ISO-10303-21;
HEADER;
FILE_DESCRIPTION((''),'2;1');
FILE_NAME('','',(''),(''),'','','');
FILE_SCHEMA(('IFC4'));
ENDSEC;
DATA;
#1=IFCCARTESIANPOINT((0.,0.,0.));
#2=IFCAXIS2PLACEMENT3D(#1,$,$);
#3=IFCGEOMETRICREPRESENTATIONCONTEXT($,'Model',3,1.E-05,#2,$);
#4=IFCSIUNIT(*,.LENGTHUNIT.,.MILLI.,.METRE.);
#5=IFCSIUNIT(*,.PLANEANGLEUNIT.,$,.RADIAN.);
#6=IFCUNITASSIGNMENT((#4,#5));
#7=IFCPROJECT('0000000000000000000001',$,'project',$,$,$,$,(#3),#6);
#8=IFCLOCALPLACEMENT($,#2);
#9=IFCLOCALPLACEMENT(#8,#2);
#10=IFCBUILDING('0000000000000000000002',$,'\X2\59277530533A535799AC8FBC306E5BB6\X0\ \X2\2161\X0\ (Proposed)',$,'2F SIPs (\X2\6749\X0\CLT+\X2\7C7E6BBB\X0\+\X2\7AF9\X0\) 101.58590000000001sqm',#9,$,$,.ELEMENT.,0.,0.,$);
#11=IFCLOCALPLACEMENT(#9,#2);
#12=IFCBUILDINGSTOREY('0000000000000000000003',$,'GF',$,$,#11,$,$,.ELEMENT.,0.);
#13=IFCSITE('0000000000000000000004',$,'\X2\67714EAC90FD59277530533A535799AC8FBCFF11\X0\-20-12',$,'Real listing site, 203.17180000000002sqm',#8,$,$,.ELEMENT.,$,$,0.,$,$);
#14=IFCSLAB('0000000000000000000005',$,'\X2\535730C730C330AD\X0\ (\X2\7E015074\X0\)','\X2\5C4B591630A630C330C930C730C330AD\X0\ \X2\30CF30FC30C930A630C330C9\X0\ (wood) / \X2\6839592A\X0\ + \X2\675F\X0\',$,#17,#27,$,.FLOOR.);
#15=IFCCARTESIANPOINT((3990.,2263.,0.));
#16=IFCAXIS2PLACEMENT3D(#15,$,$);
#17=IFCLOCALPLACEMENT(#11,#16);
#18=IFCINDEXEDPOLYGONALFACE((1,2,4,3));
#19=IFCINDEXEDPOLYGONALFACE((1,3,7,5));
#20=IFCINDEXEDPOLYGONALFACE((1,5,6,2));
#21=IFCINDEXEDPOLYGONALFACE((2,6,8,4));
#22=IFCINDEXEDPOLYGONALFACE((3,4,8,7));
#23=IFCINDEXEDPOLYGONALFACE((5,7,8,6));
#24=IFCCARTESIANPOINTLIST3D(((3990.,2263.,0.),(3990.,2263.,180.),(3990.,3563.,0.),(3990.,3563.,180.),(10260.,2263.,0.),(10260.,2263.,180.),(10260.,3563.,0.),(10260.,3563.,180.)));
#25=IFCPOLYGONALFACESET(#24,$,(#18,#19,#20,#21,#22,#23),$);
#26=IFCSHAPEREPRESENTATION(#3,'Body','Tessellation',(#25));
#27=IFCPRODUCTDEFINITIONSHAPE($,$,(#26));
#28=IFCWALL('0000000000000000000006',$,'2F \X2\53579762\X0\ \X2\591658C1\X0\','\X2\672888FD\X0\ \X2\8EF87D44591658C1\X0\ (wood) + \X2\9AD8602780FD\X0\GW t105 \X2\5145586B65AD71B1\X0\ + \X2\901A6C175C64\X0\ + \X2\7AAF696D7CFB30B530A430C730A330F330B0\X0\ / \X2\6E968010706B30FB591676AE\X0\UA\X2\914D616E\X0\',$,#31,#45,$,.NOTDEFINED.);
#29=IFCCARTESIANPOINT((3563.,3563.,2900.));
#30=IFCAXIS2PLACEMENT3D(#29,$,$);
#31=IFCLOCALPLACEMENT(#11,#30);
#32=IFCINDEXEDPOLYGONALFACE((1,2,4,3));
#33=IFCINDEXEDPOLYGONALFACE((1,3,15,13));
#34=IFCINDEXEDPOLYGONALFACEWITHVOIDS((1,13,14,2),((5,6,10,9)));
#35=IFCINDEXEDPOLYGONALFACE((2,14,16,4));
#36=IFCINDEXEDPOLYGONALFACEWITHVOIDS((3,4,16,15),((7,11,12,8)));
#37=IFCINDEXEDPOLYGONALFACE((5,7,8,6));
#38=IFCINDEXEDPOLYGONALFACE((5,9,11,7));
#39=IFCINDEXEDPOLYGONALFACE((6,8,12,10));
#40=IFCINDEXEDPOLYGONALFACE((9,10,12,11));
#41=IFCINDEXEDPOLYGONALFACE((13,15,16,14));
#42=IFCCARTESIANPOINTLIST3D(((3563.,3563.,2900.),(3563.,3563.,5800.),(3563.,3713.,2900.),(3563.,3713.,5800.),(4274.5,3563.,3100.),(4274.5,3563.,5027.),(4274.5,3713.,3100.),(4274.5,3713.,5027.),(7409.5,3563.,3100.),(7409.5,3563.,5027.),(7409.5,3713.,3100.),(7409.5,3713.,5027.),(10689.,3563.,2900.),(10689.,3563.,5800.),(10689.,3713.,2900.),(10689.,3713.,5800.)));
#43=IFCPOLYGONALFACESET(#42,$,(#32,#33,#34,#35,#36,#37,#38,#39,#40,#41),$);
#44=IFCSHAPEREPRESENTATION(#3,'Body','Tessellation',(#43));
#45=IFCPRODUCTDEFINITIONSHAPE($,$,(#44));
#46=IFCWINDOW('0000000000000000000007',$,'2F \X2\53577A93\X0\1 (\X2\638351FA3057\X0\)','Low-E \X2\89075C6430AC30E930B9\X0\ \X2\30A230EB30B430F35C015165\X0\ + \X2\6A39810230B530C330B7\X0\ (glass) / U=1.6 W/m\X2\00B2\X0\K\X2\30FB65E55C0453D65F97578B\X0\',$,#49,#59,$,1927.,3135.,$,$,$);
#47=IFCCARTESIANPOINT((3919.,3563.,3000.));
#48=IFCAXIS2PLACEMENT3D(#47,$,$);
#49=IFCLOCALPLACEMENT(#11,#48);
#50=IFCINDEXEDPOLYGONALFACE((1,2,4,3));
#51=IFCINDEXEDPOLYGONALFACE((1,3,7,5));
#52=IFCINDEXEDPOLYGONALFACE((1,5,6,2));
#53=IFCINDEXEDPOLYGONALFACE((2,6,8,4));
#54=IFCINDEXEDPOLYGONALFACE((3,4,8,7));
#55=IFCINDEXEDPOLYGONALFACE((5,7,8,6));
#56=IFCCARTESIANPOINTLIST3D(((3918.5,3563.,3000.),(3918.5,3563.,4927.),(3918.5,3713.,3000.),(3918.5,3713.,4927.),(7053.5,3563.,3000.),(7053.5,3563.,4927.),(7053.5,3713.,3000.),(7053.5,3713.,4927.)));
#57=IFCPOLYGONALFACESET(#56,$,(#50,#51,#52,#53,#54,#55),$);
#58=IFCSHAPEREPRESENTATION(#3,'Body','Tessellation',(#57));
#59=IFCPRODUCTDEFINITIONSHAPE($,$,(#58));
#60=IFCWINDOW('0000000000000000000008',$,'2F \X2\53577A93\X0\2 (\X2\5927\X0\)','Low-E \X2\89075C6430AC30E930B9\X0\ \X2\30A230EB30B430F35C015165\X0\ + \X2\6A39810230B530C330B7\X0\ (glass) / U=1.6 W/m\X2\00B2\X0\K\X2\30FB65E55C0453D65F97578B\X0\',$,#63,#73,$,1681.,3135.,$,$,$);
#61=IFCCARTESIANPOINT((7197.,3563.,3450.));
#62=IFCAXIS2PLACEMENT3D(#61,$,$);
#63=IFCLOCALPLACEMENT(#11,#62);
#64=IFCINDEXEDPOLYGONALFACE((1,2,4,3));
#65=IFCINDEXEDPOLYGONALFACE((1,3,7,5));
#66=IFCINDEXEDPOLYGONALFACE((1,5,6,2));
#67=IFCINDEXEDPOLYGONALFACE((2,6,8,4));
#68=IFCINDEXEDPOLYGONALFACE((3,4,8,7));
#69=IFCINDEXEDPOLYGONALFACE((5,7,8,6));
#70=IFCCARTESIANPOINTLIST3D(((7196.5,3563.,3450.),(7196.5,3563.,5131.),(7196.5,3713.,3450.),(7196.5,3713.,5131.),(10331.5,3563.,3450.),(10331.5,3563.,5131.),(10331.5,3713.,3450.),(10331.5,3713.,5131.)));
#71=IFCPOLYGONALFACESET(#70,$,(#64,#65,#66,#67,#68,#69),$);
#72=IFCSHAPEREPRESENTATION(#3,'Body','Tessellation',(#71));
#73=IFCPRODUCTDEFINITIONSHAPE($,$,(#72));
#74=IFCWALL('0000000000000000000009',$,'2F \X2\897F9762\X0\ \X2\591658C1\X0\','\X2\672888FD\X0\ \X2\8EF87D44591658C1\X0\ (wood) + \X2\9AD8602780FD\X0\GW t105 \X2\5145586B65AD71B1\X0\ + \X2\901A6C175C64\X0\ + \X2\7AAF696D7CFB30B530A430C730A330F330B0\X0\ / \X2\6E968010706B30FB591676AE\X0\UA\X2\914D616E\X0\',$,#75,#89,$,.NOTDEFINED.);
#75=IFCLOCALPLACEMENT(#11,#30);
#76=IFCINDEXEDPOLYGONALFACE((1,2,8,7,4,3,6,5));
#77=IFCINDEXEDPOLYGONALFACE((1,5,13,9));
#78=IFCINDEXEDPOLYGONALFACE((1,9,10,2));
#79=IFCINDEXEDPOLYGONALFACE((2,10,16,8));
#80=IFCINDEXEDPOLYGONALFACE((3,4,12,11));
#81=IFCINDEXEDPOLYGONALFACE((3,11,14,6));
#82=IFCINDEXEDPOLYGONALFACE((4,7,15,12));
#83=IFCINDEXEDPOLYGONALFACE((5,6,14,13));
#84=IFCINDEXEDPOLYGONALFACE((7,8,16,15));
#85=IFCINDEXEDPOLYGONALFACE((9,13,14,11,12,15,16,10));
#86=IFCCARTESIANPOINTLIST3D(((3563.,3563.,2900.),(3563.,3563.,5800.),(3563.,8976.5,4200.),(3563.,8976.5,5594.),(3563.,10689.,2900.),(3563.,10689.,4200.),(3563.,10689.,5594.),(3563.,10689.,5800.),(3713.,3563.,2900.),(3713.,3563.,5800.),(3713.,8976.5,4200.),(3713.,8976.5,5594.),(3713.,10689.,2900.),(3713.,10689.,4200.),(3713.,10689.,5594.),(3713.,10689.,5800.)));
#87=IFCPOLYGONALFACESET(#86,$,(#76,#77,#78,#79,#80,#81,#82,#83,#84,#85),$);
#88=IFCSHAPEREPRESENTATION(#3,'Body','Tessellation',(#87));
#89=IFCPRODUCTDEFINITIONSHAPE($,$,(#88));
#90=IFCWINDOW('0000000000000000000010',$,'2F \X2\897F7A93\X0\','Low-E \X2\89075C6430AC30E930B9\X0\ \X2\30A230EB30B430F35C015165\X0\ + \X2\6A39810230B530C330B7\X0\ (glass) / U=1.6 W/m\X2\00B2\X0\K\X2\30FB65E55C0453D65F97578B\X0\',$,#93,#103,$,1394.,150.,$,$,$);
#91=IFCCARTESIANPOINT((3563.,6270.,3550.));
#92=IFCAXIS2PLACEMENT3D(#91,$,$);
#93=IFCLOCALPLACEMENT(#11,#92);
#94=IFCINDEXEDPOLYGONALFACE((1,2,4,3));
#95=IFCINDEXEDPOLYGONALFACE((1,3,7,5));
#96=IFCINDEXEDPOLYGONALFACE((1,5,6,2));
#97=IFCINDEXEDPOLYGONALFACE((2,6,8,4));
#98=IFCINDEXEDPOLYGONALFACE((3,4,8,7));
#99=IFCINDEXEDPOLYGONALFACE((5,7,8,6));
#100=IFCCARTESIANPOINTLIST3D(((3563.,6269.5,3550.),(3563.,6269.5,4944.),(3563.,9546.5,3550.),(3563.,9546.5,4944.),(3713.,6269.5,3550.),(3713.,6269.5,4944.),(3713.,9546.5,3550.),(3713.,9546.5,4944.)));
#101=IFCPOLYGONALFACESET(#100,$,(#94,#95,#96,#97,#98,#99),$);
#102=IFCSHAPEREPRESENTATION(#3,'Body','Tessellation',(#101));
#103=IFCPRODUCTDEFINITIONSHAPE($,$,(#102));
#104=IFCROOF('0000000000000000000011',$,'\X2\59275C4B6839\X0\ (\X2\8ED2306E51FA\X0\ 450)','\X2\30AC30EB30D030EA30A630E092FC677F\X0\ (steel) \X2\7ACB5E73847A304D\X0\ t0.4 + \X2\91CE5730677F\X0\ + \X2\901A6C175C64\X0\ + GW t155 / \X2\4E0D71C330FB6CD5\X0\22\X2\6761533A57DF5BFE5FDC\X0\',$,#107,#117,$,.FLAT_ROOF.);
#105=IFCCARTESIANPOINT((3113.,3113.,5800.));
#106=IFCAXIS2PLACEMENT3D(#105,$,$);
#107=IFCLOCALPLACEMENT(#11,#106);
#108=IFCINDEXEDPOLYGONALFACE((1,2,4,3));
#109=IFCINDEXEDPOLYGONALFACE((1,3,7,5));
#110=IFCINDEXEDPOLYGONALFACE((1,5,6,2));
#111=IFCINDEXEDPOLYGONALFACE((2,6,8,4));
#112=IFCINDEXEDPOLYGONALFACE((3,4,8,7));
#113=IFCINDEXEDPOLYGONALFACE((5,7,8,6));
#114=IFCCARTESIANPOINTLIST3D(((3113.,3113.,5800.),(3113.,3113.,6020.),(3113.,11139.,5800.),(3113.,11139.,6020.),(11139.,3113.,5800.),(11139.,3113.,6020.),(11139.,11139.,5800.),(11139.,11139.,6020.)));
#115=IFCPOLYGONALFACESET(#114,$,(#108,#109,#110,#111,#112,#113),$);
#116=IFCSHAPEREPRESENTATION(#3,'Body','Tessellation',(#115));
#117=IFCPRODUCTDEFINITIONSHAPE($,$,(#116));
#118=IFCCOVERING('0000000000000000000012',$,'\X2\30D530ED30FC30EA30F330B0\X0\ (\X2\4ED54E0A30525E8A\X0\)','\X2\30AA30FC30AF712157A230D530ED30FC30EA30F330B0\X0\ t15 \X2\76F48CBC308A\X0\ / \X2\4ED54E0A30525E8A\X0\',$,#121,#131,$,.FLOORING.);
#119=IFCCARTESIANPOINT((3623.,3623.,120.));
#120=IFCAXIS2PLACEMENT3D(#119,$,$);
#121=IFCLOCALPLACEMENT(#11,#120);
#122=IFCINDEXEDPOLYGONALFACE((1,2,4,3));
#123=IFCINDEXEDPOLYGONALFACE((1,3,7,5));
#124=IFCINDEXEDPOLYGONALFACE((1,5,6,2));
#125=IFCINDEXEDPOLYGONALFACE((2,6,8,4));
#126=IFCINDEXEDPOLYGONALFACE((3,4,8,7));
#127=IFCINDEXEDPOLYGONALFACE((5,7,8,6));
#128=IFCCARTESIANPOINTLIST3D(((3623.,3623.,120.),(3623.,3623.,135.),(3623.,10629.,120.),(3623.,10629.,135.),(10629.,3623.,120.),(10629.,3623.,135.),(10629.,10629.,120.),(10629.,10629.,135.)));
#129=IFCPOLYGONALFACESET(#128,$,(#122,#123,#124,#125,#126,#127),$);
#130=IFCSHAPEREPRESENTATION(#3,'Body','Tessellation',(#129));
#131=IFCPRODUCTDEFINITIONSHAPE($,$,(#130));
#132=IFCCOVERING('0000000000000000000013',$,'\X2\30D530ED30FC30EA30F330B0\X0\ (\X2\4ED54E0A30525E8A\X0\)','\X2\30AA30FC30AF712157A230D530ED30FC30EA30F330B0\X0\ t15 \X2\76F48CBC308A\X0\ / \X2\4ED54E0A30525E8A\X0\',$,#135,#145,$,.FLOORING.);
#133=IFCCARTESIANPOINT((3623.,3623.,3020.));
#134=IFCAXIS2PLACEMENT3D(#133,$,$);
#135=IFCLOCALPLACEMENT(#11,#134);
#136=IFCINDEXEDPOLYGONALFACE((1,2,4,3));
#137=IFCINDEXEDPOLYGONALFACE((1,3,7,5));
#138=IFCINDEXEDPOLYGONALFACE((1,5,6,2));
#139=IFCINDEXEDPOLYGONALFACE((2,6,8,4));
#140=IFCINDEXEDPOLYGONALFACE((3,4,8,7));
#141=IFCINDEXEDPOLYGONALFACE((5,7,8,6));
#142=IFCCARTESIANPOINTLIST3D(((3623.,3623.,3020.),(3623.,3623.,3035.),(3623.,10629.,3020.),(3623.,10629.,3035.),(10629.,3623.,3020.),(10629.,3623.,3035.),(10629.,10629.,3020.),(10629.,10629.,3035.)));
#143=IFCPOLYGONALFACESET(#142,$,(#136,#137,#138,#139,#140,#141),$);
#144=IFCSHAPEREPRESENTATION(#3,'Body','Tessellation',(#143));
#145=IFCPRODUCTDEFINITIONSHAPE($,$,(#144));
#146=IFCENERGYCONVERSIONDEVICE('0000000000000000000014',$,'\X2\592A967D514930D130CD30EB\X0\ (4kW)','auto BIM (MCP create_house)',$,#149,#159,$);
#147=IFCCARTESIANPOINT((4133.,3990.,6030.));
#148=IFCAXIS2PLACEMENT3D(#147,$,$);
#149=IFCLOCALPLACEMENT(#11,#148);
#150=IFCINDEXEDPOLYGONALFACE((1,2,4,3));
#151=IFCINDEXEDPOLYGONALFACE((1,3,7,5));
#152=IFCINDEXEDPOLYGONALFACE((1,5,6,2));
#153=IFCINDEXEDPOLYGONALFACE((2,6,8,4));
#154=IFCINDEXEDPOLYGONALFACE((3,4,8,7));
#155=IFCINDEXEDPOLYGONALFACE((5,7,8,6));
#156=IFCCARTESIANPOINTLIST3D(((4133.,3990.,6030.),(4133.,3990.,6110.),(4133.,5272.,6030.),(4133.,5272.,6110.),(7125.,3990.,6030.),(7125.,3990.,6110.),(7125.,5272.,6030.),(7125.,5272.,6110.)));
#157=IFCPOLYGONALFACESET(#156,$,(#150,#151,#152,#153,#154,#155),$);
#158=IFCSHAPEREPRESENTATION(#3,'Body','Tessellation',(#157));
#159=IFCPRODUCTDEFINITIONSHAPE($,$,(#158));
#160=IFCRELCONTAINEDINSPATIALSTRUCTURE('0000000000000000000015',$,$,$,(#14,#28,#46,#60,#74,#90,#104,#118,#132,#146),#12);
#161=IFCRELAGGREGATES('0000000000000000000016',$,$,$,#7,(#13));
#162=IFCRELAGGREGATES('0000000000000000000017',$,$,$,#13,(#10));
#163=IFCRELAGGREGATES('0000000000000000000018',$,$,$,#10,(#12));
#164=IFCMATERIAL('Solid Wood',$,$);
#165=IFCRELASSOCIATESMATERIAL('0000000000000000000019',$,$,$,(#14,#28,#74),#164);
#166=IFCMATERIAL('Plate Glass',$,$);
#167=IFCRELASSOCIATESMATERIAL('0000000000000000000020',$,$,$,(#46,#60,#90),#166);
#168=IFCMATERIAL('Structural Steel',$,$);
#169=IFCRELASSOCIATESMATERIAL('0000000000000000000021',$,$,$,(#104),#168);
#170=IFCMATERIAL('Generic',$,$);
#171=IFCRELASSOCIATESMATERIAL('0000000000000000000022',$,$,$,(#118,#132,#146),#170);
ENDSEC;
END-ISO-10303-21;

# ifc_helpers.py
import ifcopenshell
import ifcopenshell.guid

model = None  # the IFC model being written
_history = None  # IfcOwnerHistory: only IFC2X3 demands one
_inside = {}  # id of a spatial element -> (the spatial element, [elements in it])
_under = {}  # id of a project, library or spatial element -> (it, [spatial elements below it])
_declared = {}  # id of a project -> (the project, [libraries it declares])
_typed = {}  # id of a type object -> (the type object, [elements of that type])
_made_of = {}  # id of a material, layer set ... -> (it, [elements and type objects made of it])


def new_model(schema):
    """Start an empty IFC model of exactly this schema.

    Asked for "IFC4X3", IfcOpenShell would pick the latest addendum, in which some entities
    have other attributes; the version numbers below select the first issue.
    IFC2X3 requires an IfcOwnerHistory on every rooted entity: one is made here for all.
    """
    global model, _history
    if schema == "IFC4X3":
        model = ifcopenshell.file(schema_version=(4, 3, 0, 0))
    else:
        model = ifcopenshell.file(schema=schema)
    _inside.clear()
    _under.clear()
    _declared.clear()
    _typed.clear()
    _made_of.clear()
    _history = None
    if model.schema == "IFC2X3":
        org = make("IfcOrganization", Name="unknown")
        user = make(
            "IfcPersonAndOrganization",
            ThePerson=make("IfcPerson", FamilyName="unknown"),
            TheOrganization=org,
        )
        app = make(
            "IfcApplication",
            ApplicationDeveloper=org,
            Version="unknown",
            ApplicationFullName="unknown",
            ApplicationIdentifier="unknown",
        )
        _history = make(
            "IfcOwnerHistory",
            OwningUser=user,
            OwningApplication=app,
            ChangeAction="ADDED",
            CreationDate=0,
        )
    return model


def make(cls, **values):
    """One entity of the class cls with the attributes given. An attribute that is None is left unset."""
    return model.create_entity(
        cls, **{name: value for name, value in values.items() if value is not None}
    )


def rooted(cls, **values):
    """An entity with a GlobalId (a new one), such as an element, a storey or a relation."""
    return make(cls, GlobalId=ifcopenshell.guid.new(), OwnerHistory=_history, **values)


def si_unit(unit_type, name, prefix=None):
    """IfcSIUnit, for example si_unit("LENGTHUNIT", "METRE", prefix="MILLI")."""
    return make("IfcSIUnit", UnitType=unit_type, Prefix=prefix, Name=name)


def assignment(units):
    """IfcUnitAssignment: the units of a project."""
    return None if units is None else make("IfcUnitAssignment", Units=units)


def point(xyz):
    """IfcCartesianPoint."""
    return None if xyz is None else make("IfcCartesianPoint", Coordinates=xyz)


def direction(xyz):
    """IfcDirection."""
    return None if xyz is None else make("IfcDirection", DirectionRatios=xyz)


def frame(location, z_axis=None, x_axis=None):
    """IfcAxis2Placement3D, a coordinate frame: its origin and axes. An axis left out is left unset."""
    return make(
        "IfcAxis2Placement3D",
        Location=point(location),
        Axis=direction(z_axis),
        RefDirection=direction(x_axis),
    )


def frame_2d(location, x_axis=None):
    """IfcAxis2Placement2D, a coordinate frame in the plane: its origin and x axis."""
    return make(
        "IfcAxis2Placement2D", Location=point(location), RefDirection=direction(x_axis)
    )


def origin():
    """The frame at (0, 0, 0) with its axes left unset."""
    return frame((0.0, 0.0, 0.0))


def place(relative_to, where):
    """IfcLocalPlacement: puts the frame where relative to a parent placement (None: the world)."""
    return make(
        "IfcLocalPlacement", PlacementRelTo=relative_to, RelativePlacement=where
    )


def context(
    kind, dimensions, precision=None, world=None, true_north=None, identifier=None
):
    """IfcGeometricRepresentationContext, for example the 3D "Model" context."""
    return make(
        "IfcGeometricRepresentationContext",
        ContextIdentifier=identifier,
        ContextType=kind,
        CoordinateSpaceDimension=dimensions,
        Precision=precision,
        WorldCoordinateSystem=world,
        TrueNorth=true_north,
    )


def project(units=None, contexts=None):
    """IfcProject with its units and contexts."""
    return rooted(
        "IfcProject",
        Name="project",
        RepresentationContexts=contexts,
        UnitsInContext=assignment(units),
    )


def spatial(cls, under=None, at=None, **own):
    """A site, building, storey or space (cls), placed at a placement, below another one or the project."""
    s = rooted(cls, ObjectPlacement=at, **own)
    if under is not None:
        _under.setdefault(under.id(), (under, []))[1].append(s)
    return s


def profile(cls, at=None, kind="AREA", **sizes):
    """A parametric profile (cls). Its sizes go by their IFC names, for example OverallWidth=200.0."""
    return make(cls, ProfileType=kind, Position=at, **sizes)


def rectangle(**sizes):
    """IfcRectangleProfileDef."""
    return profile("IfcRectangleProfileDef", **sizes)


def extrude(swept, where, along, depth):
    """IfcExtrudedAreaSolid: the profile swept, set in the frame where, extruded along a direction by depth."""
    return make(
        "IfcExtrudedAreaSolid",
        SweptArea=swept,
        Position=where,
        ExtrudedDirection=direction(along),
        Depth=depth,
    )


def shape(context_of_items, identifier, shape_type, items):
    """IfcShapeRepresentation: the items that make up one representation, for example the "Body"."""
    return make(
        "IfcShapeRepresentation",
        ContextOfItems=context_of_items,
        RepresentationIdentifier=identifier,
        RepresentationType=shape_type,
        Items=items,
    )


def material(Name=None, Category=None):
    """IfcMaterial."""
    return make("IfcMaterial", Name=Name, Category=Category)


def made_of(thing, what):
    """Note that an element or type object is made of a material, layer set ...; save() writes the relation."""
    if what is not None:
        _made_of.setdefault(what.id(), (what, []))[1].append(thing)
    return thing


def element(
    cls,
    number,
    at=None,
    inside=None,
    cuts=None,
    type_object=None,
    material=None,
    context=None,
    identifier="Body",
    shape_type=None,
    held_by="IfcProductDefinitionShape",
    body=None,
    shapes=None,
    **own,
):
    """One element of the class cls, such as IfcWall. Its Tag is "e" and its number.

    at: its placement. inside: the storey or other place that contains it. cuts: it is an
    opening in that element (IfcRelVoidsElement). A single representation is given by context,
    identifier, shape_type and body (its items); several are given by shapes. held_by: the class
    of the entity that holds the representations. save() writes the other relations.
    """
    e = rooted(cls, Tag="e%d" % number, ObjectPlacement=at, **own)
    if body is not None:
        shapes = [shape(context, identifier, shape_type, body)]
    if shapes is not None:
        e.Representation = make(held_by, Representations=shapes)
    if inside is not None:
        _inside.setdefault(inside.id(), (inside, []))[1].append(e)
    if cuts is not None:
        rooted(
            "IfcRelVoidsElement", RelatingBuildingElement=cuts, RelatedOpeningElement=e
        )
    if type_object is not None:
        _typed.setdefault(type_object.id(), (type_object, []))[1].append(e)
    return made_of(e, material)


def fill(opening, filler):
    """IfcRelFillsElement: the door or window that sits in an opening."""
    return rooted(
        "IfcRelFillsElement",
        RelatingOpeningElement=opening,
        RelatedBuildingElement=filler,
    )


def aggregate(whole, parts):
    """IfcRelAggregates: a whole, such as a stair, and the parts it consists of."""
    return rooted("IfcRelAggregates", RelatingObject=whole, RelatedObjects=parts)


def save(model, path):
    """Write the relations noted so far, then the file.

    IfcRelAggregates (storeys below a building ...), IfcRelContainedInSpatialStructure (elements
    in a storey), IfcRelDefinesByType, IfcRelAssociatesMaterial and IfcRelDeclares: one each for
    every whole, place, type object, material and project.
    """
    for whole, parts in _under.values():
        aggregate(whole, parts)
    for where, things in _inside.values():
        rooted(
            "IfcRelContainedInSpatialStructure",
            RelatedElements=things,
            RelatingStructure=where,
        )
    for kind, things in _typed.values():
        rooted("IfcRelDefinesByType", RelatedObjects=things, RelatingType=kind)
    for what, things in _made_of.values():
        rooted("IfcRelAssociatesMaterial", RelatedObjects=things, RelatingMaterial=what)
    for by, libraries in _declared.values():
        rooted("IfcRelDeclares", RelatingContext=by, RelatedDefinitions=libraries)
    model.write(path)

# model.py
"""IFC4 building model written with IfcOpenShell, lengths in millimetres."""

from ifc_helpers import new_model, si_unit, frame, frame_2d, origin, place, context, project, spatial, rectangle, extrude, material, element, fill, save


model = new_model("IFC4")

# Units and contexts
model_context = context("Model", 3, precision=1e-05, world=origin())
ifc_project = project(units=[si_unit("LENGTHUNIT", "METRE", prefix="MILLI"), si_unit("PLANEANGLEUNIT", "RADIAN")], contexts=[model_context])

# Site, building, storey
site_placement = place(None, origin())
site = spatial("IfcSite", under=ifc_project, at=site_placement, Name="東京都大田区南馬込１-20-12", ObjectType="Real listing site, 203.17180000000002sqm", CompositionType="ELEMENT", RefElevation=0.0)
building_placement = place(site_placement, origin())
building = spatial("IfcBuilding", under=site, at=building_placement, Name="大田区南馬込の家 Ⅱ (Proposed)", ObjectType="2F SIPs (杉CLT+籾殻+竹) 101.58590000000001sqm", CompositionType="ELEMENT", ElevationOfRefHeight=0.0, ElevationOfTerrain=0.0)
storey_placement = place(building_placement, origin())
storey = spatial("IfcBuildingStorey", under=building, at=storey_placement, Name="GF", CompositionType="ELEMENT", Elevation=0.0)

# Slab
ifc_material_1 = material(Name="Solid Wood")
slab_1_placement = place(storey_placement, frame((3990.0, 2263.0, 0.0)))
element("IfcSlab", 1, at=slab_1_placement, inside=storey, material=ifc_material_1, Name="南デッキ (縁側)", Description="屋外ウッドデッキ ハードウッド (wood) / 根太 + 束", PredefinedType="FLOOR", context=model_context, shape_type="SweptSolid", body=[
    extrude(rectangle(XDim=6270.0, YDim=1300.0, at=frame_2d((3135.0, 650.0))), frame((3990.0, 2263.0, 0.0)), (0.0, 0.0, 1.0), 180.0),
])

# Shared definitions
ifc_material_2 = material(Name="Plate Glass")

# Wall, openings, windows
wall_1_placement = place(storey_placement, frame((3563.0, 3563.0, 2900.0)))
wall_1 = element("IfcWall", 2, at=wall_1_placement, inside=storey, material=ifc_material_1, Name="2F 南面 外壁", Description="木製 軸組外壁 (wood) + 高性能GW t105 充填断熱 + 通気層 + 窯業系サイディング / 準耐火・外皮UA配慮", PredefinedType="NOTDEFINED", context=model_context, shape_type="SweptSolid", body=[
    extrude(rectangle(XDim=7126.0, YDim=150.0, at=frame_2d((3563.0, 75.0))), frame((3563.0, 3563.0, 2900.0)), (0.0, 0.0, 1.0), 2900.0),
])
opening_1_placement = place(storey_placement, frame((3919.0, 3563.0, 3000.0)))
opening_1 = element("IfcOpeningElement", 3, at=opening_1_placement, cuts=wall_1, PredefinedType="NOTDEFINED", context=model_context, shape_type="SweptSolid", body=[
    extrude(rectangle(XDim=3135.0, YDim=150.0, at=frame_2d((1567.0, 75.0))), frame((3919.0, 3563.0, 3000.0)), (0.0, 0.0, 1.0), 1927.0),
])
opening_2_placement = place(storey_placement, frame((7197.0, 3563.0, 3450.0)))
opening_2 = element("IfcOpeningElement", 4, at=opening_2_placement, cuts=wall_1, PredefinedType="NOTDEFINED", context=model_context, shape_type="SweptSolid", body=[
    extrude(rectangle(XDim=3135.0, YDim=150.0, at=frame_2d((1567.0, 75.0))), frame((7197.0, 3563.0, 3450.0)), (0.0, 0.0, 1.0), 1681.0),
])
window_1_placement = place(storey_placement, frame((3919.0, 3563.0, 3000.0)))
window_1 = element("IfcWindow", 5, at=window_1_placement, inside=storey, material=ifc_material_2, Name="2F 南窓1 (掃出し)", Description="Low-E 複層ガラス アルゴン封入 + 樹脂サッシ (glass) / U=1.6 W/m²K・日射取得型", OverallHeight=1927.0, OverallWidth=3135.0, context=model_context, shape_type="SweptSolid", body=[
    extrude(rectangle(XDim=3135.0, YDim=150.0, at=frame_2d((1567.0, 75.0))), frame((3919.0, 3563.0, 3000.0)), (0.0, 0.0, 1.0), 1927.0),
])
fill(opening_1, window_1)
window_2_placement = place(storey_placement, frame((7197.0, 3563.0, 3450.0)))
window_2 = element("IfcWindow", 6, at=window_2_placement, inside=storey, material=ifc_material_2, Name="2F 南窓2 (大)", Description="Low-E 複層ガラス アルゴン封入 + 樹脂サッシ (glass) / U=1.6 W/m²K・日射取得型", OverallHeight=1681.0, OverallWidth=3135.0, context=model_context, shape_type="SweptSolid", body=[
    extrude(rectangle(XDim=3135.0, YDim=150.0, at=frame_2d((1567.0, 75.0))), frame((7197.0, 3563.0, 3450.0)), (0.0, 0.0, 1.0), 1681.0),
])
fill(opening_2, window_2)

# Wall, opening, window
wall_2_placement = place(storey_placement, frame((3563.0, 3563.0, 2900.0)))
wall_2 = element("IfcWall", 7, at=wall_2_placement, inside=storey, material=ifc_material_1, Name="2F 西面 外壁", Description="木製 軸組外壁 (wood) + 高性能GW t105 充填断熱 + 通気層 + 窯業系サイディング / 準耐火・外皮UA配慮", PredefinedType="NOTDEFINED", context=model_context, shape_type="SweptSolid", body=[
    extrude(rectangle(XDim=150.0, YDim=7126.0, at=frame_2d((75.0, 3563.0))), frame((3563.0, 3563.0, 2900.0)), (0.0, 0.0, 1.0), 2900.0),
])
opening_3_placement = place(storey_placement, frame((3563.0, 6270.0, 3550.0)))
opening_3 = element("IfcOpeningElement", 8, at=opening_3_placement, cuts=wall_2, PredefinedType="NOTDEFINED", context=model_context, shape_type="SweptSolid", body=[
    extrude(rectangle(XDim=150.0, YDim=3277.0, at=frame_2d((75.0, 1638.0))), frame((3563.0, 6270.0, 3550.0)), (0.0, 0.0, 1.0), 1394.0),
])
window_3_placement = place(storey_placement, frame((3563.0, 6270.0, 3550.0)))
window_3 = element("IfcWindow", 9, at=window_3_placement, inside=storey, material=ifc_material_2, Name="2F 西窓", Description="Low-E 複層ガラス アルゴン封入 + 樹脂サッシ (glass) / U=1.6 W/m²K・日射取得型", OverallHeight=1394.0, OverallWidth=150.0, context=model_context, shape_type="SweptSolid", body=[
    extrude(rectangle(XDim=150.0, YDim=3277.0, at=frame_2d((75.0, 1638.0))), frame((3563.0, 6270.0, 3550.0)), (0.0, 0.0, 1.0), 1394.0),
])
fill(opening_3, window_3)

# Roof
ifc_material_3 = material(Name="Structural Steel")
roof_placement = place(storey_placement, frame((3113.0, 3113.0, 5800.0)))
element("IfcRoof", 10, at=roof_placement, inside=storey, material=ifc_material_3, Name="大屋根 (軒の出 450)", Description="ガルバリウム鋼板 (steel) 立平葺き t0.4 + 野地板 + 通気層 + GW t155 / 不燃・法22条区域対応", PredefinedType="FLAT_ROOF", context=model_context, shape_type="SweptSolid", body=[
    extrude(rectangle(XDim=8026.0, YDim=8026.0, at=frame_2d((4013.0, 4013.0))), frame((3113.0, 3113.0, 5800.0)), (0.0, 0.0, 1.0), 220.0),
])

# Coverings
ifc_material_4 = material(Name="Generic")
covering_1_placement = place(storey_placement, frame((3623.0, 3623.0, 120.0)))
element("IfcCovering", 11, at=covering_1_placement, inside=storey, material=ifc_material_4, Name="フローリング (仕上げ床)", Description="オーク無垢フローリング t15 直貼り / 仕上げ床", PredefinedType="FLOORING", context=model_context, shape_type="SweptSolid", body=[
    extrude(rectangle(XDim=7006.0, YDim=7006.0, at=frame_2d((3503.0, 3503.0))), frame((3623.0, 3623.0, 120.0)), (0.0, 0.0, 1.0), 15.0),
])
covering_2_placement = place(storey_placement, frame((3623.0, 3623.0, 3020.0)))
element("IfcCovering", 12, at=covering_2_placement, inside=storey, material=ifc_material_4, Name="フローリング (仕上げ床)", Description="オーク無垢フローリング t15 直貼り / 仕上げ床", PredefinedType="FLOORING", context=model_context, shape_type="SweptSolid", body=[
    extrude(rectangle(XDim=7006.0, YDim=7006.0, at=frame_2d((3503.0, 3503.0))), frame((3623.0, 3623.0, 3020.0)), (0.0, 0.0, 1.0), 15.0),
])

# Energy conversion device
energy_conversion_device_placement = place(storey_placement, frame((4133.0, 3990.0, 6030.0)))
element("IfcEnergyConversionDevice", 13, at=energy_conversion_device_placement, inside=storey, material=ifc_material_4, Name="太陽光パネル (4kW)", Description="auto BIM (MCP create_house)", context=model_context, shape_type="SweptSolid", body=[
    extrude(rectangle(XDim=2992.0, YDim=1282.0, at=frame_2d((1496.0, 641.0))), frame((4133.0, 3990.0, 6030.0)), (0.0, 0.0, 1.0), 80.0),
])

save(model, "model.ifc")
